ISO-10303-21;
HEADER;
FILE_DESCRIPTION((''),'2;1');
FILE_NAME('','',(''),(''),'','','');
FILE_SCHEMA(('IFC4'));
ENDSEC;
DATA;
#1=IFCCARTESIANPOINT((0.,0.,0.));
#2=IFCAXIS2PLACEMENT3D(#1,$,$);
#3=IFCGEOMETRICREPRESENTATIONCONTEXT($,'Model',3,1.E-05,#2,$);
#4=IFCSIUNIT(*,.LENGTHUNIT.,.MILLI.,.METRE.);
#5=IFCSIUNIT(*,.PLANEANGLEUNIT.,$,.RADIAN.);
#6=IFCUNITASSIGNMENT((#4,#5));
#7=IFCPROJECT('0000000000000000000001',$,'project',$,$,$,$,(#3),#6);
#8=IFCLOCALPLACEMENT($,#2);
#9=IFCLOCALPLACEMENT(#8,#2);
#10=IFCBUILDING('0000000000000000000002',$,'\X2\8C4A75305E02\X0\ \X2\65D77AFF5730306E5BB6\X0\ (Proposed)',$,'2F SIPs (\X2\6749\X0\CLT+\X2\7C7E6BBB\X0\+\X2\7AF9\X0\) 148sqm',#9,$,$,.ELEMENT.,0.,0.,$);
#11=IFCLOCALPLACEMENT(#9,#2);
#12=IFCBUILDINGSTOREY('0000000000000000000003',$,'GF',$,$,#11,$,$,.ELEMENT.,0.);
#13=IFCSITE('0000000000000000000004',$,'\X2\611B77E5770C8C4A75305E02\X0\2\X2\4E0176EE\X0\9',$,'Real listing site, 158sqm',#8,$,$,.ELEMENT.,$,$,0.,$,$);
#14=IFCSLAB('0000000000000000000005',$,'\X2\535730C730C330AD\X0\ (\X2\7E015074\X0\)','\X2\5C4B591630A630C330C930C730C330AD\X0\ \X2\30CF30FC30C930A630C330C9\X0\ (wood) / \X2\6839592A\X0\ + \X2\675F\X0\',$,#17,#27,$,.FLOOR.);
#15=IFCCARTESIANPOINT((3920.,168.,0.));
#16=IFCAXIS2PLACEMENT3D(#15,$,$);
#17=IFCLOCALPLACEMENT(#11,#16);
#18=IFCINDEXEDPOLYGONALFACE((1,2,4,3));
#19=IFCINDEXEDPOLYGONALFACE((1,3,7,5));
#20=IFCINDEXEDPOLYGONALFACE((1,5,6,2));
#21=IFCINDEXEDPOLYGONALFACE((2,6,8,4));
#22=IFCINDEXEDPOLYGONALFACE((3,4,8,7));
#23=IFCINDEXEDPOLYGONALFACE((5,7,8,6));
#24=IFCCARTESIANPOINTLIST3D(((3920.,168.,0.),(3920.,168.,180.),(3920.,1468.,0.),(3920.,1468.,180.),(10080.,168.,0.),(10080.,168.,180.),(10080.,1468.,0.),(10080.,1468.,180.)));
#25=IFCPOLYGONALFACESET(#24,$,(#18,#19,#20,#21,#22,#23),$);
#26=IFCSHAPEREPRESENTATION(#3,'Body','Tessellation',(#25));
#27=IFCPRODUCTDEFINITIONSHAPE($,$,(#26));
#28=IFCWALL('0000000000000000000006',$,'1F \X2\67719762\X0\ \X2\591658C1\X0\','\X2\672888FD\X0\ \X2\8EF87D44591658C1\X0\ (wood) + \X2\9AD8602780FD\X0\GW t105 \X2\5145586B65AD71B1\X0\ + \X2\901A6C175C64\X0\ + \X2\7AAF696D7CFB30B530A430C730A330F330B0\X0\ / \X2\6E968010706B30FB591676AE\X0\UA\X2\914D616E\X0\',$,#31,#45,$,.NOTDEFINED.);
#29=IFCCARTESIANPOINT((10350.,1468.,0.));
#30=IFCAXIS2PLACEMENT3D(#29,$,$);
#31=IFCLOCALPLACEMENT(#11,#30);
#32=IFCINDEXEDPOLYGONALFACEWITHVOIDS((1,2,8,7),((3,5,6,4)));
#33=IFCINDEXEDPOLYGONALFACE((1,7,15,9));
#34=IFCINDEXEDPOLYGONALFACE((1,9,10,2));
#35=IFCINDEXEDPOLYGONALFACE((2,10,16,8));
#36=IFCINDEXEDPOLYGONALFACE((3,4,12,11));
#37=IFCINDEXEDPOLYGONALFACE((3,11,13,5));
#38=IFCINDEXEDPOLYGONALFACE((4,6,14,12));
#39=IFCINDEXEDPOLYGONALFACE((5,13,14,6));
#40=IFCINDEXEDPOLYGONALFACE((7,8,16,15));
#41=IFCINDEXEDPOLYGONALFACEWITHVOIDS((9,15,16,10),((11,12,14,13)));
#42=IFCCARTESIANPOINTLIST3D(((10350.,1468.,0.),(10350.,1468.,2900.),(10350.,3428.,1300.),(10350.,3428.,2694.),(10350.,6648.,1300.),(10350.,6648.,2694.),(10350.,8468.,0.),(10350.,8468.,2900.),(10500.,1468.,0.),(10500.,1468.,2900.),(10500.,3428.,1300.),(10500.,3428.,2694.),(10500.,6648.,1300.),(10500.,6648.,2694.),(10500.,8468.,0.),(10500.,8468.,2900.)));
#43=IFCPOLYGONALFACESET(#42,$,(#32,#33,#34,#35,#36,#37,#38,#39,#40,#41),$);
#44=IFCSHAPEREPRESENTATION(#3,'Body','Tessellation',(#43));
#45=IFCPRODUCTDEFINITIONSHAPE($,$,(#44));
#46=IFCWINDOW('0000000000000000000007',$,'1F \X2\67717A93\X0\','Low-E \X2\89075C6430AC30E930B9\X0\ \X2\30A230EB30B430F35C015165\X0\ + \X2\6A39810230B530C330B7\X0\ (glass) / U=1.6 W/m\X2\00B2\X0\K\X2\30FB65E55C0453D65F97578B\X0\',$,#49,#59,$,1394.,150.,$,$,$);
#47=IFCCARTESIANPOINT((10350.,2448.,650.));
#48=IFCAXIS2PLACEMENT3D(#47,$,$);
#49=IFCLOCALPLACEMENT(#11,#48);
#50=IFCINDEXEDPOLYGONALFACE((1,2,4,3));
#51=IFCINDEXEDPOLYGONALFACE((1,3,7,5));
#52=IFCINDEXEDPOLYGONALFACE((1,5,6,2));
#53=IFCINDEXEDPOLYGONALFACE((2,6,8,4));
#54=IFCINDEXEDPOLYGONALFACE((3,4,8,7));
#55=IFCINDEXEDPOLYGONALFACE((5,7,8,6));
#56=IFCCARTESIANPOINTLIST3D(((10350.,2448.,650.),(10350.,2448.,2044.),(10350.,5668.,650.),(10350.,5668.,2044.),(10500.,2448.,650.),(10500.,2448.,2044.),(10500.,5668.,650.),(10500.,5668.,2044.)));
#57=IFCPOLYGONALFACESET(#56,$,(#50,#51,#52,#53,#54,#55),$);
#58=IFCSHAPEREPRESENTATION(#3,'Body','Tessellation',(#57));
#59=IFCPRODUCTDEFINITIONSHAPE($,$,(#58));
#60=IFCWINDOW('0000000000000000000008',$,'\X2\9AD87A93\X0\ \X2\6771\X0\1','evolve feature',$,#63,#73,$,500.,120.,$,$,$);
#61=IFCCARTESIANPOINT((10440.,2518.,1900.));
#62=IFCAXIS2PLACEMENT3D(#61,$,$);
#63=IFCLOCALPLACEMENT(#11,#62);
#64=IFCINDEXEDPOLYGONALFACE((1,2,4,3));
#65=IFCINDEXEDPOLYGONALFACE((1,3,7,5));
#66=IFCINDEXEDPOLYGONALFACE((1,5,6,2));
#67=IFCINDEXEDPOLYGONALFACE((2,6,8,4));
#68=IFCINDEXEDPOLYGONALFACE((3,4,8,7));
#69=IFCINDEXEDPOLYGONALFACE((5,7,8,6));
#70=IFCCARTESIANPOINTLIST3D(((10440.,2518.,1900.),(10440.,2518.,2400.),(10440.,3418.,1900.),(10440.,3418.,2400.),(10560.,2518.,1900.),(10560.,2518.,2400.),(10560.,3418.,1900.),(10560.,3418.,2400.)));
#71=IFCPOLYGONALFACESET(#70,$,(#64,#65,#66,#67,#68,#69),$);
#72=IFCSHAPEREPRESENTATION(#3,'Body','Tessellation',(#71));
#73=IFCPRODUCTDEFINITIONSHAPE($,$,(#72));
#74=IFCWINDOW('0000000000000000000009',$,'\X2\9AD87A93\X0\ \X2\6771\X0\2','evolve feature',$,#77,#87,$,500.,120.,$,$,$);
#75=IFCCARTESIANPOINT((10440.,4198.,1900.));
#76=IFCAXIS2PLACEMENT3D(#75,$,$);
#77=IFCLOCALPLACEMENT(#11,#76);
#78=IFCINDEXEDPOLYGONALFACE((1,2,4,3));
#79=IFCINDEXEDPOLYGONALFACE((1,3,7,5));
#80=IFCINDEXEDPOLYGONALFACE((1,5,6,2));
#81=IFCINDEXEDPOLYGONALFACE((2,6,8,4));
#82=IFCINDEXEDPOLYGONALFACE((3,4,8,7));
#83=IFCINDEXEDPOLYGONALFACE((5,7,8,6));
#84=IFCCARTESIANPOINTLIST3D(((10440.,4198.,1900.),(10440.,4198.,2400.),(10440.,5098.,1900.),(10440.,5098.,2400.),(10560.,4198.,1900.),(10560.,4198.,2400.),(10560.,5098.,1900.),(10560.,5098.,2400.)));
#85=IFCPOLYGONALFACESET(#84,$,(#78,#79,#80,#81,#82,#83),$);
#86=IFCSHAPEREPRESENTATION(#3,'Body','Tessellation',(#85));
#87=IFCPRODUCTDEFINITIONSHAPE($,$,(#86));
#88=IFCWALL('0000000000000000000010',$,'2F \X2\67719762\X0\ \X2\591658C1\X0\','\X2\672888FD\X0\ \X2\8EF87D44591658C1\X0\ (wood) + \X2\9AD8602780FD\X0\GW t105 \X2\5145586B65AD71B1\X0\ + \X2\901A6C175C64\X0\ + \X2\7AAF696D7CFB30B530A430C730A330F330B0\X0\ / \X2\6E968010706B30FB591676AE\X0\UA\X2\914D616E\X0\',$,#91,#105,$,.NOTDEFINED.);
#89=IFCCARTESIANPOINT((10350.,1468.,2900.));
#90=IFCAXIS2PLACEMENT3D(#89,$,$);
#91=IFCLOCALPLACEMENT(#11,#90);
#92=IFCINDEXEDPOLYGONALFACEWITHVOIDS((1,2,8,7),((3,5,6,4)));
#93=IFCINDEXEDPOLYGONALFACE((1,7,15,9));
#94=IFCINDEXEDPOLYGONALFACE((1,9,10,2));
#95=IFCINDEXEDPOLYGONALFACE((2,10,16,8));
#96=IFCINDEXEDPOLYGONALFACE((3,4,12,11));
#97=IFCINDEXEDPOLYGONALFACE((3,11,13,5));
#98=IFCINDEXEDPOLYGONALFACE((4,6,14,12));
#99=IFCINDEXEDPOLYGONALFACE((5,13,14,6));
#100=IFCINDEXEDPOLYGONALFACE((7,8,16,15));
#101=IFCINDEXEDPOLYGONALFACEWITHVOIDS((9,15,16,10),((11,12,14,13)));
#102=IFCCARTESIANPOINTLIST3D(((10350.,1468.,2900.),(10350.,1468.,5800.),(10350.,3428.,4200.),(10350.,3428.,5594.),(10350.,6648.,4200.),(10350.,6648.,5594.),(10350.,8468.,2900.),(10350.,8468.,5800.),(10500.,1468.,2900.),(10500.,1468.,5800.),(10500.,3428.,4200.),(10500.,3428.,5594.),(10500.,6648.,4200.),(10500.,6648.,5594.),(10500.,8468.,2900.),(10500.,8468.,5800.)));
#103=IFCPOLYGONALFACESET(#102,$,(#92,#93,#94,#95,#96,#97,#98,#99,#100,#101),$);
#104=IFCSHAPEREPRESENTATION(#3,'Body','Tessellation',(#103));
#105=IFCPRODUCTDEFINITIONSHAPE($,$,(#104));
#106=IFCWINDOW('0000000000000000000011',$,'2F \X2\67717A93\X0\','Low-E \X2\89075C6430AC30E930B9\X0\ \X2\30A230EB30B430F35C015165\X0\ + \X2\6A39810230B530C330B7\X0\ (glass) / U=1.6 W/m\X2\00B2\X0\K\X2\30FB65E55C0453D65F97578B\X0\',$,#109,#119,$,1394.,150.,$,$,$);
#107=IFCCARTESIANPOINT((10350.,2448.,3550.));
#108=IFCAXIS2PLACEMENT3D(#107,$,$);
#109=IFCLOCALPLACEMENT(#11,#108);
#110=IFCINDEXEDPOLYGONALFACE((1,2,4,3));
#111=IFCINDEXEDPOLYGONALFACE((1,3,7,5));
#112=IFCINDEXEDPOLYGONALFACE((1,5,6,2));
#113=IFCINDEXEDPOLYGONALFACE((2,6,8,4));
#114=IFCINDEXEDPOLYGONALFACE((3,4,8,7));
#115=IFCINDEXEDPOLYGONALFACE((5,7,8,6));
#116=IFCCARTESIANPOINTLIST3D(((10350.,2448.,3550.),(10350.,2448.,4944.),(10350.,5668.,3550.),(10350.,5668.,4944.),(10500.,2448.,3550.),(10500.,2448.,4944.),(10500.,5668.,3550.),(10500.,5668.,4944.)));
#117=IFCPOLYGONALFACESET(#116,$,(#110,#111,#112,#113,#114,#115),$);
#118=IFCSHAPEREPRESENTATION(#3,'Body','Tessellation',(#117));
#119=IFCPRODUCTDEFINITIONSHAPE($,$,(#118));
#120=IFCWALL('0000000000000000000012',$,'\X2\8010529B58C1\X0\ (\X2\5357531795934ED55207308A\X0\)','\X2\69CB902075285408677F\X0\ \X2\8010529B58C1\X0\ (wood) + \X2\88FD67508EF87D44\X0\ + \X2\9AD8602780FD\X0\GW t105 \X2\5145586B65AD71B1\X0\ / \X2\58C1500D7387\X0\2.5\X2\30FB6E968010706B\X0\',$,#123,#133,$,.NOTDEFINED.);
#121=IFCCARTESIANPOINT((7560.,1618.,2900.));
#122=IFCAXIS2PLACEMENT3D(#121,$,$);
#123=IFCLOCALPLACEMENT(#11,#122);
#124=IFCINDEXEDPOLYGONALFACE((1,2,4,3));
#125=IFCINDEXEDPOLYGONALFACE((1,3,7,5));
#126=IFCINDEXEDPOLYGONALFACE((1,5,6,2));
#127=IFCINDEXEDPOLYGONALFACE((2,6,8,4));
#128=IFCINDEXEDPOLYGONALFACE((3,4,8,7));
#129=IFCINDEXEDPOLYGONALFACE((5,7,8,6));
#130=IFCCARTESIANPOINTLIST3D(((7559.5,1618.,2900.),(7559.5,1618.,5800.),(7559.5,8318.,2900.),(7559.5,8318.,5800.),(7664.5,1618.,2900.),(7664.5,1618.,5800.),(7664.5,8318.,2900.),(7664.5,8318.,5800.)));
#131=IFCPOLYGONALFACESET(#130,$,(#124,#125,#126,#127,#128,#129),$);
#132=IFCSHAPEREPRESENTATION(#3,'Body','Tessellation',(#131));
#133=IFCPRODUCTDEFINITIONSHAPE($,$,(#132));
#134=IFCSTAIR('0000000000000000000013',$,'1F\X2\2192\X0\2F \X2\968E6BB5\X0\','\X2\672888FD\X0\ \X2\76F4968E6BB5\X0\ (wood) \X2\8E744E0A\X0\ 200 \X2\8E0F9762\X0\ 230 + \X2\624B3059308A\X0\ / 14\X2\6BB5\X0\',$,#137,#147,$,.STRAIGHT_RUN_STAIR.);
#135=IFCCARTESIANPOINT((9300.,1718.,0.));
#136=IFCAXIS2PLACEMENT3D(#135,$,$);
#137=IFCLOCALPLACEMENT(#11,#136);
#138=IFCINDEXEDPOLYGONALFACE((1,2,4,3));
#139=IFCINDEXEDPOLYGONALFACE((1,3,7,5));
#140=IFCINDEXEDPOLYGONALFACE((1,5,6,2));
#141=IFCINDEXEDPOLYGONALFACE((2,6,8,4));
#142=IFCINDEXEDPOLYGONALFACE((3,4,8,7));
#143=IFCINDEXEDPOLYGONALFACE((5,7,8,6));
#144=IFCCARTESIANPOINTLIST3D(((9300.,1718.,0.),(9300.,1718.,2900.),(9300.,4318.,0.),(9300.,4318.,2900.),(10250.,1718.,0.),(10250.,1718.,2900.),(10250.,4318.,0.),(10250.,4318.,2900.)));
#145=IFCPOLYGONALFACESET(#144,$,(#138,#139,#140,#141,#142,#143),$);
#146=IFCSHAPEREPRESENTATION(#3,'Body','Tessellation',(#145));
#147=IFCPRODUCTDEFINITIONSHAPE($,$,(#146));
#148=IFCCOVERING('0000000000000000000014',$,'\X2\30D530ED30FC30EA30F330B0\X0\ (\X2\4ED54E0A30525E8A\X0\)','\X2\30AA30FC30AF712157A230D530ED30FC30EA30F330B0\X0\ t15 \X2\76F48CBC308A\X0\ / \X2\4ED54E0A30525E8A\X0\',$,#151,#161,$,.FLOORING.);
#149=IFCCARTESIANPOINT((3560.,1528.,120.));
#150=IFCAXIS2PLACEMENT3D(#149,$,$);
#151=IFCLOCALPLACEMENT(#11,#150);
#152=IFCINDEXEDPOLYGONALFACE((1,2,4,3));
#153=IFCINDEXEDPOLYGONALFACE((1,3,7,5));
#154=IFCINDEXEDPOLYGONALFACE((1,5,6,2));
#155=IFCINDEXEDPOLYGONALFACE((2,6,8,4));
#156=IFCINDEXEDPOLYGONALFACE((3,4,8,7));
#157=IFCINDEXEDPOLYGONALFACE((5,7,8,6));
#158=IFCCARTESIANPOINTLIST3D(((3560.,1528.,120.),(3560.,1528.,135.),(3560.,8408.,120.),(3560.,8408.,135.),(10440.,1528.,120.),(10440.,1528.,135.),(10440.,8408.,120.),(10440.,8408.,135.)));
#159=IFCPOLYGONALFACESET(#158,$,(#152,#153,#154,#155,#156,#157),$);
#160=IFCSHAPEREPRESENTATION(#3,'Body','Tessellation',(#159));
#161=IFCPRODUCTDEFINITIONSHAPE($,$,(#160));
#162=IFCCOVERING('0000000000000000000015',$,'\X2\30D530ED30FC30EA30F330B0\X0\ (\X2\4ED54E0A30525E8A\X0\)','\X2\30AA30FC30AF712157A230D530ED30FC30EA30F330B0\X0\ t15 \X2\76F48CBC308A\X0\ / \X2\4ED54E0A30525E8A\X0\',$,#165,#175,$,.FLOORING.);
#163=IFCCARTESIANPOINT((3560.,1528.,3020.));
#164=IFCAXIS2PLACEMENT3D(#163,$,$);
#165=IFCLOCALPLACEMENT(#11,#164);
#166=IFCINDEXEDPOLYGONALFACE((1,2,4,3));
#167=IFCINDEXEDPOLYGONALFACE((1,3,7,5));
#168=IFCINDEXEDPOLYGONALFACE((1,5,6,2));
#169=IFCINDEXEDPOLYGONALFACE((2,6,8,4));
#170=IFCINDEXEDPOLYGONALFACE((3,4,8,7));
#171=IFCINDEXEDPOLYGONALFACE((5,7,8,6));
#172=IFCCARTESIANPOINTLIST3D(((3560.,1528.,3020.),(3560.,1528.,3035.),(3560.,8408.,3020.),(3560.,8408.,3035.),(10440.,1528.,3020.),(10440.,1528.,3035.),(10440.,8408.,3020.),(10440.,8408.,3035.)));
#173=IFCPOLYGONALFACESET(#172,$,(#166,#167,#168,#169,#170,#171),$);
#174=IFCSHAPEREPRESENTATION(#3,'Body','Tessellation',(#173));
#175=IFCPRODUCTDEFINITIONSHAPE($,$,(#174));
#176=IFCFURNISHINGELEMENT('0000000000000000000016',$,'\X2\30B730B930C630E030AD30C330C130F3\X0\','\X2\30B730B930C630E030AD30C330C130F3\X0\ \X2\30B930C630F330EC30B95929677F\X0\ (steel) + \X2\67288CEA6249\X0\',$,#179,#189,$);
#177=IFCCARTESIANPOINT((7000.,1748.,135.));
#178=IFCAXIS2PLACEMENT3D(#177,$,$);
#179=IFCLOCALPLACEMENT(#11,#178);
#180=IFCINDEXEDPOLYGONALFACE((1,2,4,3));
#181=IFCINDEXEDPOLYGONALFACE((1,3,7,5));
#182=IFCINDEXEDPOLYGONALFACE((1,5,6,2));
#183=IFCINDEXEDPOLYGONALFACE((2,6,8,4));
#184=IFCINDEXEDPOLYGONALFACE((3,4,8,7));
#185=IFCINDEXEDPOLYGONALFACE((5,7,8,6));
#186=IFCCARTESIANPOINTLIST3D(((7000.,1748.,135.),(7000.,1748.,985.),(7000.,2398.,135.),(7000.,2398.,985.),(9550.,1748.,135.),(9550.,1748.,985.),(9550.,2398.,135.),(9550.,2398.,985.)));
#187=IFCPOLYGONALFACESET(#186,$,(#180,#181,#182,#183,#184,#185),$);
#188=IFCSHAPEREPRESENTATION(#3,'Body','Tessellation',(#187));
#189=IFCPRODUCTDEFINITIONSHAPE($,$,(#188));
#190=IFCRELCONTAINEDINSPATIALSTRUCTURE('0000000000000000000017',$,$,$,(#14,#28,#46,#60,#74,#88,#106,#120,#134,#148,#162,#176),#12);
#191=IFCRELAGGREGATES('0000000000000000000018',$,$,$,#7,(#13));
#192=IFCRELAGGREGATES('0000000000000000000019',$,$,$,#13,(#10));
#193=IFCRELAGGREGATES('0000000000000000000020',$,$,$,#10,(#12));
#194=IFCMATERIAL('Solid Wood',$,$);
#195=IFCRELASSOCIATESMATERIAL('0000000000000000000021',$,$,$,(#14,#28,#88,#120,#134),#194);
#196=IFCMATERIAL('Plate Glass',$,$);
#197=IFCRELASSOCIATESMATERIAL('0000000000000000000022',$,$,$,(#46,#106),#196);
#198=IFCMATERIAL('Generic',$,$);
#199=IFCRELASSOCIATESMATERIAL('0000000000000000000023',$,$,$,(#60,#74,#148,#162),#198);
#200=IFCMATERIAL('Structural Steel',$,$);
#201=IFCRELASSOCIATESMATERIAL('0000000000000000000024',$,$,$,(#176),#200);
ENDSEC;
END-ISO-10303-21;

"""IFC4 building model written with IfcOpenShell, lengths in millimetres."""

from ifc_helpers import new_model, si_unit, frame, frame_2d, origin, place, context, project, spatial, rectangle, extrude, material, element, fill, save


model = new_model("IFC4")

# Units and contexts
model_context = context("Model", 3, precision=1e-05, world=origin())
ifc_project = project(units=[si_unit("LENGTHUNIT", "METRE", prefix="MILLI"), si_unit("PLANEANGLEUNIT", "RADIAN")], contexts=[model_context])

# Site, building, storey
site_placement = place(None, origin())
site = spatial("IfcSite", under=ifc_project, at=site_placement, Name="愛知県豊田市2丁目9", ObjectType="Real listing site, 158sqm", CompositionType="ELEMENT", RefElevation=0.0)
building_placement = place(site_placement, origin())
building = spatial("IfcBuilding", under=site, at=building_placement, Name="豊田市 旗竿地の家 (Proposed)", ObjectType="2F SIPs (杉CLT+籾殻+竹) 148sqm", CompositionType="ELEMENT", ElevationOfRefHeight=0.0, ElevationOfTerrain=0.0)
storey_placement = place(building_placement, origin())
storey = spatial("IfcBuildingStorey", under=building, at=storey_placement, Name="GF", CompositionType="ELEMENT", Elevation=0.0)

# Slab
ifc_material_1 = material(Name="Solid Wood")
slab_placement = place(storey_placement, frame((3920.0, 168.0, 0.0)))
element("IfcSlab", 1, at=slab_placement, inside=storey, material=ifc_material_1, Name="南デッキ (縁側)", Description="屋外ウッドデッキ ハードウッド (wood) / 根太 + 束", PredefinedType="FLOOR", context=model_context, shape_type="SweptSolid", body=[
    extrude(rectangle(XDim=6160.0, YDim=1300.0, at=frame_2d((3080.0, 650.0))), frame((3920.0, 168.0, 0.0)), (0.0, 0.0, 1.0), 180.0),
])

# Wall, openings, windows
wall_1_placement = place(storey_placement, frame((10350.0, 1468.0, 0.0)))
wall_1 = element("IfcWall", 2, at=wall_1_placement, inside=storey, material=ifc_material_1, Name="1F 東面 外壁", Description="木製 軸組外壁 (wood) + 高性能GW t105 充填断熱 + 通気層 + 窯業系サイディング / 準耐火・外皮UA配慮", PredefinedType="NOTDEFINED", context=model_context, shape_type="SweptSolid", body=[
    extrude(rectangle(XDim=150.0, YDim=7000.0, at=frame_2d((75.0, 3500.0))), frame((10350.0, 1468.0, 0.0)), (0.0, 0.0, 1.0), 2900.0),
])
opening_1_placement = place(storey_placement, frame((10350.0, 2448.0, 650.0)))
opening_1 = element("IfcOpeningElement", 3, at=opening_1_placement, cuts=wall_1, PredefinedType="NOTDEFINED", context=model_context, shape_type="SweptSolid", body=[
    extrude(rectangle(XDim=150.0, YDim=3220.0, at=frame_2d((75.0, 1610.0))), frame((10350.0, 2448.0, 650.0)), (0.0, 0.0, 1.0), 1394.0),
])
opening_2_placement = place(storey_placement, frame((10440.0, 2518.0, 1900.0)))
opening_2 = element("IfcOpeningElement", 4, at=opening_2_placement, cuts=wall_1, PredefinedType="NOTDEFINED", context=model_context, shape_type="SweptSolid", body=[
    extrude(rectangle(XDim=120.0, YDim=900.0, at=frame_2d((60.0, 450.0))), frame((10440.0, 2518.0, 1900.0)), (0.0, 0.0, 1.0), 500.0),
])
opening_3_placement = place(storey_placement, frame((10440.0, 4198.0, 1900.0)))
opening_3 = element("IfcOpeningElement", 5, at=opening_3_placement, cuts=wall_1, PredefinedType="NOTDEFINED", context=model_context, shape_type="SweptSolid", body=[
    extrude(rectangle(XDim=120.0, YDim=900.0, at=frame_2d((60.0, 450.0))), frame((10440.0, 4198.0, 1900.0)), (0.0, 0.0, 1.0), 500.0),
])
ifc_material_2 = material(Name="Plate Glass")
window_1_placement = place(storey_placement, frame((10350.0, 2448.0, 650.0)))
window_1 = element("IfcWindow", 6, at=window_1_placement, inside=storey, material=ifc_material_2, Name="1F 東窓", Description="Low-E 複層ガラス アルゴン封入 + 樹脂サッシ (glass) / U=1.6 W/m²K・日射取得型", OverallHeight=1394.0, OverallWidth=150.0, context=model_context, shape_type="SweptSolid", body=[
    extrude(rectangle(XDim=150.0, YDim=3220.0, at=frame_2d((75.0, 1610.0))), frame((10350.0, 2448.0, 650.0)), (0.0, 0.0, 1.0), 1394.0),
])
fill(opening_1, window_1)
ifc_material_3 = material(Name="Generic")
window_2_placement = place(storey_placement, frame((10440.0, 2518.0, 1900.0)))
window_2 = element("IfcWindow", 7, at=window_2_placement, inside=storey, material=ifc_material_3, Name="高窓 東1", Description="evolve feature", OverallHeight=500.0, OverallWidth=120.0, context=model_context, shape_type="SweptSolid", body=[
    extrude(rectangle(XDim=120.0, YDim=900.0, at=frame_2d((60.0, 450.0))), frame((10440.0, 2518.0, 1900.0)), (0.0, 0.0, 1.0), 500.0),
])
fill(opening_2, window_2)
window_3_placement = place(storey_placement, frame((10440.0, 4198.0, 1900.0)))
window_3 = element("IfcWindow", 8, at=window_3_placement, inside=storey, material=ifc_material_3, Name="高窓 東2", Description="evolve feature", OverallHeight=500.0, OverallWidth=120.0, context=model_context, shape_type="SweptSolid", body=[
    extrude(rectangle(XDim=120.0, YDim=900.0, at=frame_2d((60.0, 450.0))), frame((10440.0, 4198.0, 1900.0)), (0.0, 0.0, 1.0), 500.0),
])
fill(opening_3, window_3)

# Wall, opening, window
wall_2_placement = place(storey_placement, frame((10350.0, 1468.0, 2900.0)))
wall_2 = element("IfcWall", 9, at=wall_2_placement, inside=storey, material=ifc_material_1, Name="2F 東面 外壁", Description="木製 軸組外壁 (wood) + 高性能GW t105 充填断熱 + 通気層 + 窯業系サイディング / 準耐火・外皮UA配慮", PredefinedType="NOTDEFINED", context=model_context, shape_type="SweptSolid", body=[
    extrude(rectangle(XDim=150.0, YDim=7000.0, at=frame_2d((75.0, 3500.0))), frame((10350.0, 1468.0, 2900.0)), (0.0, 0.0, 1.0), 2900.0),
])
opening_4_placement = place(storey_placement, frame((10350.0, 2448.0, 3550.0)))
opening_4 = element("IfcOpeningElement", 10, at=opening_4_placement, cuts=wall_2, PredefinedType="NOTDEFINED", context=model_context, shape_type="SweptSolid", body=[
    extrude(rectangle(XDim=150.0, YDim=3220.0, at=frame_2d((75.0, 1610.0))), frame((10350.0, 2448.0, 3550.0)), (0.0, 0.0, 1.0), 1394.0),
])
window_4_placement = place(storey_placement, frame((10350.0, 2448.0, 3550.0)))
window_4 = element("IfcWindow", 11, at=window_4_placement, inside=storey, material=ifc_material_2, Name="2F 東窓", Description="Low-E 複層ガラス アルゴン封入 + 樹脂サッシ (glass) / U=1.6 W/m²K・日射取得型", OverallHeight=1394.0, OverallWidth=150.0, context=model_context, shape_type="SweptSolid", body=[
    extrude(rectangle(XDim=150.0, YDim=3220.0, at=frame_2d((75.0, 1610.0))), frame((10350.0, 2448.0, 3550.0)), (0.0, 0.0, 1.0), 1394.0),
])
fill(opening_4, window_4)

# Wall
wall_3_placement = place(storey_placement, frame((7560.0, 1618.0, 2900.0)))
element("IfcWall", 12, at=wall_3_placement, inside=storey, material=ifc_material_1, Name="耐力壁 (南北間仕切り)", Description="構造用合板 耐力壁 (wood) + 製材軸組 + 高性能GW t105 充填断熱 / 壁倍率2.5・準耐火", PredefinedType="NOTDEFINED", context=model_context, shape_type="SweptSolid", body=[
    extrude(rectangle(XDim=105.0, YDim=6700.0, at=frame_2d((52.0, 3350.0))), frame((7560.0, 1618.0, 2900.0)), (0.0, 0.0, 1.0), 2900.0),
])

# Stair
stair_placement = place(storey_placement, frame((9300.0, 1718.0, 0.0)))
element("IfcStair", 13, at=stair_placement, inside=storey, material=ifc_material_1, Name="1F→2F 階段", Description="木製 直階段 (wood) 蹴上 200 踏面 230 + 手すり / 14段", PredefinedType="STRAIGHT_RUN_STAIR", context=model_context, shape_type="SweptSolid", body=[
    extrude(rectangle(XDim=950.0, YDim=2600.0, at=frame_2d((475.0, 1300.0))), frame((9300.0, 1718.0, 0.0)), (0.0, 0.0, 1.0), 2900.0),
])

# Coverings
covering_1_placement = place(storey_placement, frame((3560.0, 1528.0, 120.0)))
element("IfcCovering", 14, at=covering_1_placement, inside=storey, material=ifc_material_3, Name="フローリング (仕上げ床)", Description="オーク無垢フローリング t15 直貼り / 仕上げ床", PredefinedType="FLOORING", context=model_context, shape_type="SweptSolid", body=[
    extrude(rectangle(XDim=6880.0, YDim=6880.0, at=frame_2d((3440.0, 3440.0))), frame((3560.0, 1528.0, 120.0)), (0.0, 0.0, 1.0), 15.0),
])
covering_2_placement = place(storey_placement, frame((3560.0, 1528.0, 3020.0)))
element("IfcCovering", 15, at=covering_2_placement, inside=storey, material=ifc_material_3, Name="フローリング (仕上げ床)", Description="オーク無垢フローリング t15 直貼り / 仕上げ床", PredefinedType="FLOORING", context=model_context, shape_type="SweptSolid", body=[
    extrude(rectangle(XDim=6880.0, YDim=6880.0, at=frame_2d((3440.0, 3440.0))), frame((3560.0, 1528.0, 3020.0)), (0.0, 0.0, 1.0), 15.0),
])

# Furnishing element
ifc_material_4 = material(Name="Structural Steel")
furnishing_1_placement = place(storey_placement, frame((7000.0, 1748.0, 135.0)))
element("IfcFurnishingElement", 16, at=furnishing_1_placement, inside=storey, material=ifc_material_4, Name="システムキッチン", Description="システムキッチン ステンレス天板 (steel) + 木質扉", context=model_context, shape_type="SweptSolid", body=[
    extrude(rectangle(XDim=2550.0, YDim=650.0, at=frame_2d((1275.0, 325.0))), frame((7000.0, 1748.0, 135.0)), (0.0, 0.0, 1.0), 850.0),
])

save(model, "model.ifc")
